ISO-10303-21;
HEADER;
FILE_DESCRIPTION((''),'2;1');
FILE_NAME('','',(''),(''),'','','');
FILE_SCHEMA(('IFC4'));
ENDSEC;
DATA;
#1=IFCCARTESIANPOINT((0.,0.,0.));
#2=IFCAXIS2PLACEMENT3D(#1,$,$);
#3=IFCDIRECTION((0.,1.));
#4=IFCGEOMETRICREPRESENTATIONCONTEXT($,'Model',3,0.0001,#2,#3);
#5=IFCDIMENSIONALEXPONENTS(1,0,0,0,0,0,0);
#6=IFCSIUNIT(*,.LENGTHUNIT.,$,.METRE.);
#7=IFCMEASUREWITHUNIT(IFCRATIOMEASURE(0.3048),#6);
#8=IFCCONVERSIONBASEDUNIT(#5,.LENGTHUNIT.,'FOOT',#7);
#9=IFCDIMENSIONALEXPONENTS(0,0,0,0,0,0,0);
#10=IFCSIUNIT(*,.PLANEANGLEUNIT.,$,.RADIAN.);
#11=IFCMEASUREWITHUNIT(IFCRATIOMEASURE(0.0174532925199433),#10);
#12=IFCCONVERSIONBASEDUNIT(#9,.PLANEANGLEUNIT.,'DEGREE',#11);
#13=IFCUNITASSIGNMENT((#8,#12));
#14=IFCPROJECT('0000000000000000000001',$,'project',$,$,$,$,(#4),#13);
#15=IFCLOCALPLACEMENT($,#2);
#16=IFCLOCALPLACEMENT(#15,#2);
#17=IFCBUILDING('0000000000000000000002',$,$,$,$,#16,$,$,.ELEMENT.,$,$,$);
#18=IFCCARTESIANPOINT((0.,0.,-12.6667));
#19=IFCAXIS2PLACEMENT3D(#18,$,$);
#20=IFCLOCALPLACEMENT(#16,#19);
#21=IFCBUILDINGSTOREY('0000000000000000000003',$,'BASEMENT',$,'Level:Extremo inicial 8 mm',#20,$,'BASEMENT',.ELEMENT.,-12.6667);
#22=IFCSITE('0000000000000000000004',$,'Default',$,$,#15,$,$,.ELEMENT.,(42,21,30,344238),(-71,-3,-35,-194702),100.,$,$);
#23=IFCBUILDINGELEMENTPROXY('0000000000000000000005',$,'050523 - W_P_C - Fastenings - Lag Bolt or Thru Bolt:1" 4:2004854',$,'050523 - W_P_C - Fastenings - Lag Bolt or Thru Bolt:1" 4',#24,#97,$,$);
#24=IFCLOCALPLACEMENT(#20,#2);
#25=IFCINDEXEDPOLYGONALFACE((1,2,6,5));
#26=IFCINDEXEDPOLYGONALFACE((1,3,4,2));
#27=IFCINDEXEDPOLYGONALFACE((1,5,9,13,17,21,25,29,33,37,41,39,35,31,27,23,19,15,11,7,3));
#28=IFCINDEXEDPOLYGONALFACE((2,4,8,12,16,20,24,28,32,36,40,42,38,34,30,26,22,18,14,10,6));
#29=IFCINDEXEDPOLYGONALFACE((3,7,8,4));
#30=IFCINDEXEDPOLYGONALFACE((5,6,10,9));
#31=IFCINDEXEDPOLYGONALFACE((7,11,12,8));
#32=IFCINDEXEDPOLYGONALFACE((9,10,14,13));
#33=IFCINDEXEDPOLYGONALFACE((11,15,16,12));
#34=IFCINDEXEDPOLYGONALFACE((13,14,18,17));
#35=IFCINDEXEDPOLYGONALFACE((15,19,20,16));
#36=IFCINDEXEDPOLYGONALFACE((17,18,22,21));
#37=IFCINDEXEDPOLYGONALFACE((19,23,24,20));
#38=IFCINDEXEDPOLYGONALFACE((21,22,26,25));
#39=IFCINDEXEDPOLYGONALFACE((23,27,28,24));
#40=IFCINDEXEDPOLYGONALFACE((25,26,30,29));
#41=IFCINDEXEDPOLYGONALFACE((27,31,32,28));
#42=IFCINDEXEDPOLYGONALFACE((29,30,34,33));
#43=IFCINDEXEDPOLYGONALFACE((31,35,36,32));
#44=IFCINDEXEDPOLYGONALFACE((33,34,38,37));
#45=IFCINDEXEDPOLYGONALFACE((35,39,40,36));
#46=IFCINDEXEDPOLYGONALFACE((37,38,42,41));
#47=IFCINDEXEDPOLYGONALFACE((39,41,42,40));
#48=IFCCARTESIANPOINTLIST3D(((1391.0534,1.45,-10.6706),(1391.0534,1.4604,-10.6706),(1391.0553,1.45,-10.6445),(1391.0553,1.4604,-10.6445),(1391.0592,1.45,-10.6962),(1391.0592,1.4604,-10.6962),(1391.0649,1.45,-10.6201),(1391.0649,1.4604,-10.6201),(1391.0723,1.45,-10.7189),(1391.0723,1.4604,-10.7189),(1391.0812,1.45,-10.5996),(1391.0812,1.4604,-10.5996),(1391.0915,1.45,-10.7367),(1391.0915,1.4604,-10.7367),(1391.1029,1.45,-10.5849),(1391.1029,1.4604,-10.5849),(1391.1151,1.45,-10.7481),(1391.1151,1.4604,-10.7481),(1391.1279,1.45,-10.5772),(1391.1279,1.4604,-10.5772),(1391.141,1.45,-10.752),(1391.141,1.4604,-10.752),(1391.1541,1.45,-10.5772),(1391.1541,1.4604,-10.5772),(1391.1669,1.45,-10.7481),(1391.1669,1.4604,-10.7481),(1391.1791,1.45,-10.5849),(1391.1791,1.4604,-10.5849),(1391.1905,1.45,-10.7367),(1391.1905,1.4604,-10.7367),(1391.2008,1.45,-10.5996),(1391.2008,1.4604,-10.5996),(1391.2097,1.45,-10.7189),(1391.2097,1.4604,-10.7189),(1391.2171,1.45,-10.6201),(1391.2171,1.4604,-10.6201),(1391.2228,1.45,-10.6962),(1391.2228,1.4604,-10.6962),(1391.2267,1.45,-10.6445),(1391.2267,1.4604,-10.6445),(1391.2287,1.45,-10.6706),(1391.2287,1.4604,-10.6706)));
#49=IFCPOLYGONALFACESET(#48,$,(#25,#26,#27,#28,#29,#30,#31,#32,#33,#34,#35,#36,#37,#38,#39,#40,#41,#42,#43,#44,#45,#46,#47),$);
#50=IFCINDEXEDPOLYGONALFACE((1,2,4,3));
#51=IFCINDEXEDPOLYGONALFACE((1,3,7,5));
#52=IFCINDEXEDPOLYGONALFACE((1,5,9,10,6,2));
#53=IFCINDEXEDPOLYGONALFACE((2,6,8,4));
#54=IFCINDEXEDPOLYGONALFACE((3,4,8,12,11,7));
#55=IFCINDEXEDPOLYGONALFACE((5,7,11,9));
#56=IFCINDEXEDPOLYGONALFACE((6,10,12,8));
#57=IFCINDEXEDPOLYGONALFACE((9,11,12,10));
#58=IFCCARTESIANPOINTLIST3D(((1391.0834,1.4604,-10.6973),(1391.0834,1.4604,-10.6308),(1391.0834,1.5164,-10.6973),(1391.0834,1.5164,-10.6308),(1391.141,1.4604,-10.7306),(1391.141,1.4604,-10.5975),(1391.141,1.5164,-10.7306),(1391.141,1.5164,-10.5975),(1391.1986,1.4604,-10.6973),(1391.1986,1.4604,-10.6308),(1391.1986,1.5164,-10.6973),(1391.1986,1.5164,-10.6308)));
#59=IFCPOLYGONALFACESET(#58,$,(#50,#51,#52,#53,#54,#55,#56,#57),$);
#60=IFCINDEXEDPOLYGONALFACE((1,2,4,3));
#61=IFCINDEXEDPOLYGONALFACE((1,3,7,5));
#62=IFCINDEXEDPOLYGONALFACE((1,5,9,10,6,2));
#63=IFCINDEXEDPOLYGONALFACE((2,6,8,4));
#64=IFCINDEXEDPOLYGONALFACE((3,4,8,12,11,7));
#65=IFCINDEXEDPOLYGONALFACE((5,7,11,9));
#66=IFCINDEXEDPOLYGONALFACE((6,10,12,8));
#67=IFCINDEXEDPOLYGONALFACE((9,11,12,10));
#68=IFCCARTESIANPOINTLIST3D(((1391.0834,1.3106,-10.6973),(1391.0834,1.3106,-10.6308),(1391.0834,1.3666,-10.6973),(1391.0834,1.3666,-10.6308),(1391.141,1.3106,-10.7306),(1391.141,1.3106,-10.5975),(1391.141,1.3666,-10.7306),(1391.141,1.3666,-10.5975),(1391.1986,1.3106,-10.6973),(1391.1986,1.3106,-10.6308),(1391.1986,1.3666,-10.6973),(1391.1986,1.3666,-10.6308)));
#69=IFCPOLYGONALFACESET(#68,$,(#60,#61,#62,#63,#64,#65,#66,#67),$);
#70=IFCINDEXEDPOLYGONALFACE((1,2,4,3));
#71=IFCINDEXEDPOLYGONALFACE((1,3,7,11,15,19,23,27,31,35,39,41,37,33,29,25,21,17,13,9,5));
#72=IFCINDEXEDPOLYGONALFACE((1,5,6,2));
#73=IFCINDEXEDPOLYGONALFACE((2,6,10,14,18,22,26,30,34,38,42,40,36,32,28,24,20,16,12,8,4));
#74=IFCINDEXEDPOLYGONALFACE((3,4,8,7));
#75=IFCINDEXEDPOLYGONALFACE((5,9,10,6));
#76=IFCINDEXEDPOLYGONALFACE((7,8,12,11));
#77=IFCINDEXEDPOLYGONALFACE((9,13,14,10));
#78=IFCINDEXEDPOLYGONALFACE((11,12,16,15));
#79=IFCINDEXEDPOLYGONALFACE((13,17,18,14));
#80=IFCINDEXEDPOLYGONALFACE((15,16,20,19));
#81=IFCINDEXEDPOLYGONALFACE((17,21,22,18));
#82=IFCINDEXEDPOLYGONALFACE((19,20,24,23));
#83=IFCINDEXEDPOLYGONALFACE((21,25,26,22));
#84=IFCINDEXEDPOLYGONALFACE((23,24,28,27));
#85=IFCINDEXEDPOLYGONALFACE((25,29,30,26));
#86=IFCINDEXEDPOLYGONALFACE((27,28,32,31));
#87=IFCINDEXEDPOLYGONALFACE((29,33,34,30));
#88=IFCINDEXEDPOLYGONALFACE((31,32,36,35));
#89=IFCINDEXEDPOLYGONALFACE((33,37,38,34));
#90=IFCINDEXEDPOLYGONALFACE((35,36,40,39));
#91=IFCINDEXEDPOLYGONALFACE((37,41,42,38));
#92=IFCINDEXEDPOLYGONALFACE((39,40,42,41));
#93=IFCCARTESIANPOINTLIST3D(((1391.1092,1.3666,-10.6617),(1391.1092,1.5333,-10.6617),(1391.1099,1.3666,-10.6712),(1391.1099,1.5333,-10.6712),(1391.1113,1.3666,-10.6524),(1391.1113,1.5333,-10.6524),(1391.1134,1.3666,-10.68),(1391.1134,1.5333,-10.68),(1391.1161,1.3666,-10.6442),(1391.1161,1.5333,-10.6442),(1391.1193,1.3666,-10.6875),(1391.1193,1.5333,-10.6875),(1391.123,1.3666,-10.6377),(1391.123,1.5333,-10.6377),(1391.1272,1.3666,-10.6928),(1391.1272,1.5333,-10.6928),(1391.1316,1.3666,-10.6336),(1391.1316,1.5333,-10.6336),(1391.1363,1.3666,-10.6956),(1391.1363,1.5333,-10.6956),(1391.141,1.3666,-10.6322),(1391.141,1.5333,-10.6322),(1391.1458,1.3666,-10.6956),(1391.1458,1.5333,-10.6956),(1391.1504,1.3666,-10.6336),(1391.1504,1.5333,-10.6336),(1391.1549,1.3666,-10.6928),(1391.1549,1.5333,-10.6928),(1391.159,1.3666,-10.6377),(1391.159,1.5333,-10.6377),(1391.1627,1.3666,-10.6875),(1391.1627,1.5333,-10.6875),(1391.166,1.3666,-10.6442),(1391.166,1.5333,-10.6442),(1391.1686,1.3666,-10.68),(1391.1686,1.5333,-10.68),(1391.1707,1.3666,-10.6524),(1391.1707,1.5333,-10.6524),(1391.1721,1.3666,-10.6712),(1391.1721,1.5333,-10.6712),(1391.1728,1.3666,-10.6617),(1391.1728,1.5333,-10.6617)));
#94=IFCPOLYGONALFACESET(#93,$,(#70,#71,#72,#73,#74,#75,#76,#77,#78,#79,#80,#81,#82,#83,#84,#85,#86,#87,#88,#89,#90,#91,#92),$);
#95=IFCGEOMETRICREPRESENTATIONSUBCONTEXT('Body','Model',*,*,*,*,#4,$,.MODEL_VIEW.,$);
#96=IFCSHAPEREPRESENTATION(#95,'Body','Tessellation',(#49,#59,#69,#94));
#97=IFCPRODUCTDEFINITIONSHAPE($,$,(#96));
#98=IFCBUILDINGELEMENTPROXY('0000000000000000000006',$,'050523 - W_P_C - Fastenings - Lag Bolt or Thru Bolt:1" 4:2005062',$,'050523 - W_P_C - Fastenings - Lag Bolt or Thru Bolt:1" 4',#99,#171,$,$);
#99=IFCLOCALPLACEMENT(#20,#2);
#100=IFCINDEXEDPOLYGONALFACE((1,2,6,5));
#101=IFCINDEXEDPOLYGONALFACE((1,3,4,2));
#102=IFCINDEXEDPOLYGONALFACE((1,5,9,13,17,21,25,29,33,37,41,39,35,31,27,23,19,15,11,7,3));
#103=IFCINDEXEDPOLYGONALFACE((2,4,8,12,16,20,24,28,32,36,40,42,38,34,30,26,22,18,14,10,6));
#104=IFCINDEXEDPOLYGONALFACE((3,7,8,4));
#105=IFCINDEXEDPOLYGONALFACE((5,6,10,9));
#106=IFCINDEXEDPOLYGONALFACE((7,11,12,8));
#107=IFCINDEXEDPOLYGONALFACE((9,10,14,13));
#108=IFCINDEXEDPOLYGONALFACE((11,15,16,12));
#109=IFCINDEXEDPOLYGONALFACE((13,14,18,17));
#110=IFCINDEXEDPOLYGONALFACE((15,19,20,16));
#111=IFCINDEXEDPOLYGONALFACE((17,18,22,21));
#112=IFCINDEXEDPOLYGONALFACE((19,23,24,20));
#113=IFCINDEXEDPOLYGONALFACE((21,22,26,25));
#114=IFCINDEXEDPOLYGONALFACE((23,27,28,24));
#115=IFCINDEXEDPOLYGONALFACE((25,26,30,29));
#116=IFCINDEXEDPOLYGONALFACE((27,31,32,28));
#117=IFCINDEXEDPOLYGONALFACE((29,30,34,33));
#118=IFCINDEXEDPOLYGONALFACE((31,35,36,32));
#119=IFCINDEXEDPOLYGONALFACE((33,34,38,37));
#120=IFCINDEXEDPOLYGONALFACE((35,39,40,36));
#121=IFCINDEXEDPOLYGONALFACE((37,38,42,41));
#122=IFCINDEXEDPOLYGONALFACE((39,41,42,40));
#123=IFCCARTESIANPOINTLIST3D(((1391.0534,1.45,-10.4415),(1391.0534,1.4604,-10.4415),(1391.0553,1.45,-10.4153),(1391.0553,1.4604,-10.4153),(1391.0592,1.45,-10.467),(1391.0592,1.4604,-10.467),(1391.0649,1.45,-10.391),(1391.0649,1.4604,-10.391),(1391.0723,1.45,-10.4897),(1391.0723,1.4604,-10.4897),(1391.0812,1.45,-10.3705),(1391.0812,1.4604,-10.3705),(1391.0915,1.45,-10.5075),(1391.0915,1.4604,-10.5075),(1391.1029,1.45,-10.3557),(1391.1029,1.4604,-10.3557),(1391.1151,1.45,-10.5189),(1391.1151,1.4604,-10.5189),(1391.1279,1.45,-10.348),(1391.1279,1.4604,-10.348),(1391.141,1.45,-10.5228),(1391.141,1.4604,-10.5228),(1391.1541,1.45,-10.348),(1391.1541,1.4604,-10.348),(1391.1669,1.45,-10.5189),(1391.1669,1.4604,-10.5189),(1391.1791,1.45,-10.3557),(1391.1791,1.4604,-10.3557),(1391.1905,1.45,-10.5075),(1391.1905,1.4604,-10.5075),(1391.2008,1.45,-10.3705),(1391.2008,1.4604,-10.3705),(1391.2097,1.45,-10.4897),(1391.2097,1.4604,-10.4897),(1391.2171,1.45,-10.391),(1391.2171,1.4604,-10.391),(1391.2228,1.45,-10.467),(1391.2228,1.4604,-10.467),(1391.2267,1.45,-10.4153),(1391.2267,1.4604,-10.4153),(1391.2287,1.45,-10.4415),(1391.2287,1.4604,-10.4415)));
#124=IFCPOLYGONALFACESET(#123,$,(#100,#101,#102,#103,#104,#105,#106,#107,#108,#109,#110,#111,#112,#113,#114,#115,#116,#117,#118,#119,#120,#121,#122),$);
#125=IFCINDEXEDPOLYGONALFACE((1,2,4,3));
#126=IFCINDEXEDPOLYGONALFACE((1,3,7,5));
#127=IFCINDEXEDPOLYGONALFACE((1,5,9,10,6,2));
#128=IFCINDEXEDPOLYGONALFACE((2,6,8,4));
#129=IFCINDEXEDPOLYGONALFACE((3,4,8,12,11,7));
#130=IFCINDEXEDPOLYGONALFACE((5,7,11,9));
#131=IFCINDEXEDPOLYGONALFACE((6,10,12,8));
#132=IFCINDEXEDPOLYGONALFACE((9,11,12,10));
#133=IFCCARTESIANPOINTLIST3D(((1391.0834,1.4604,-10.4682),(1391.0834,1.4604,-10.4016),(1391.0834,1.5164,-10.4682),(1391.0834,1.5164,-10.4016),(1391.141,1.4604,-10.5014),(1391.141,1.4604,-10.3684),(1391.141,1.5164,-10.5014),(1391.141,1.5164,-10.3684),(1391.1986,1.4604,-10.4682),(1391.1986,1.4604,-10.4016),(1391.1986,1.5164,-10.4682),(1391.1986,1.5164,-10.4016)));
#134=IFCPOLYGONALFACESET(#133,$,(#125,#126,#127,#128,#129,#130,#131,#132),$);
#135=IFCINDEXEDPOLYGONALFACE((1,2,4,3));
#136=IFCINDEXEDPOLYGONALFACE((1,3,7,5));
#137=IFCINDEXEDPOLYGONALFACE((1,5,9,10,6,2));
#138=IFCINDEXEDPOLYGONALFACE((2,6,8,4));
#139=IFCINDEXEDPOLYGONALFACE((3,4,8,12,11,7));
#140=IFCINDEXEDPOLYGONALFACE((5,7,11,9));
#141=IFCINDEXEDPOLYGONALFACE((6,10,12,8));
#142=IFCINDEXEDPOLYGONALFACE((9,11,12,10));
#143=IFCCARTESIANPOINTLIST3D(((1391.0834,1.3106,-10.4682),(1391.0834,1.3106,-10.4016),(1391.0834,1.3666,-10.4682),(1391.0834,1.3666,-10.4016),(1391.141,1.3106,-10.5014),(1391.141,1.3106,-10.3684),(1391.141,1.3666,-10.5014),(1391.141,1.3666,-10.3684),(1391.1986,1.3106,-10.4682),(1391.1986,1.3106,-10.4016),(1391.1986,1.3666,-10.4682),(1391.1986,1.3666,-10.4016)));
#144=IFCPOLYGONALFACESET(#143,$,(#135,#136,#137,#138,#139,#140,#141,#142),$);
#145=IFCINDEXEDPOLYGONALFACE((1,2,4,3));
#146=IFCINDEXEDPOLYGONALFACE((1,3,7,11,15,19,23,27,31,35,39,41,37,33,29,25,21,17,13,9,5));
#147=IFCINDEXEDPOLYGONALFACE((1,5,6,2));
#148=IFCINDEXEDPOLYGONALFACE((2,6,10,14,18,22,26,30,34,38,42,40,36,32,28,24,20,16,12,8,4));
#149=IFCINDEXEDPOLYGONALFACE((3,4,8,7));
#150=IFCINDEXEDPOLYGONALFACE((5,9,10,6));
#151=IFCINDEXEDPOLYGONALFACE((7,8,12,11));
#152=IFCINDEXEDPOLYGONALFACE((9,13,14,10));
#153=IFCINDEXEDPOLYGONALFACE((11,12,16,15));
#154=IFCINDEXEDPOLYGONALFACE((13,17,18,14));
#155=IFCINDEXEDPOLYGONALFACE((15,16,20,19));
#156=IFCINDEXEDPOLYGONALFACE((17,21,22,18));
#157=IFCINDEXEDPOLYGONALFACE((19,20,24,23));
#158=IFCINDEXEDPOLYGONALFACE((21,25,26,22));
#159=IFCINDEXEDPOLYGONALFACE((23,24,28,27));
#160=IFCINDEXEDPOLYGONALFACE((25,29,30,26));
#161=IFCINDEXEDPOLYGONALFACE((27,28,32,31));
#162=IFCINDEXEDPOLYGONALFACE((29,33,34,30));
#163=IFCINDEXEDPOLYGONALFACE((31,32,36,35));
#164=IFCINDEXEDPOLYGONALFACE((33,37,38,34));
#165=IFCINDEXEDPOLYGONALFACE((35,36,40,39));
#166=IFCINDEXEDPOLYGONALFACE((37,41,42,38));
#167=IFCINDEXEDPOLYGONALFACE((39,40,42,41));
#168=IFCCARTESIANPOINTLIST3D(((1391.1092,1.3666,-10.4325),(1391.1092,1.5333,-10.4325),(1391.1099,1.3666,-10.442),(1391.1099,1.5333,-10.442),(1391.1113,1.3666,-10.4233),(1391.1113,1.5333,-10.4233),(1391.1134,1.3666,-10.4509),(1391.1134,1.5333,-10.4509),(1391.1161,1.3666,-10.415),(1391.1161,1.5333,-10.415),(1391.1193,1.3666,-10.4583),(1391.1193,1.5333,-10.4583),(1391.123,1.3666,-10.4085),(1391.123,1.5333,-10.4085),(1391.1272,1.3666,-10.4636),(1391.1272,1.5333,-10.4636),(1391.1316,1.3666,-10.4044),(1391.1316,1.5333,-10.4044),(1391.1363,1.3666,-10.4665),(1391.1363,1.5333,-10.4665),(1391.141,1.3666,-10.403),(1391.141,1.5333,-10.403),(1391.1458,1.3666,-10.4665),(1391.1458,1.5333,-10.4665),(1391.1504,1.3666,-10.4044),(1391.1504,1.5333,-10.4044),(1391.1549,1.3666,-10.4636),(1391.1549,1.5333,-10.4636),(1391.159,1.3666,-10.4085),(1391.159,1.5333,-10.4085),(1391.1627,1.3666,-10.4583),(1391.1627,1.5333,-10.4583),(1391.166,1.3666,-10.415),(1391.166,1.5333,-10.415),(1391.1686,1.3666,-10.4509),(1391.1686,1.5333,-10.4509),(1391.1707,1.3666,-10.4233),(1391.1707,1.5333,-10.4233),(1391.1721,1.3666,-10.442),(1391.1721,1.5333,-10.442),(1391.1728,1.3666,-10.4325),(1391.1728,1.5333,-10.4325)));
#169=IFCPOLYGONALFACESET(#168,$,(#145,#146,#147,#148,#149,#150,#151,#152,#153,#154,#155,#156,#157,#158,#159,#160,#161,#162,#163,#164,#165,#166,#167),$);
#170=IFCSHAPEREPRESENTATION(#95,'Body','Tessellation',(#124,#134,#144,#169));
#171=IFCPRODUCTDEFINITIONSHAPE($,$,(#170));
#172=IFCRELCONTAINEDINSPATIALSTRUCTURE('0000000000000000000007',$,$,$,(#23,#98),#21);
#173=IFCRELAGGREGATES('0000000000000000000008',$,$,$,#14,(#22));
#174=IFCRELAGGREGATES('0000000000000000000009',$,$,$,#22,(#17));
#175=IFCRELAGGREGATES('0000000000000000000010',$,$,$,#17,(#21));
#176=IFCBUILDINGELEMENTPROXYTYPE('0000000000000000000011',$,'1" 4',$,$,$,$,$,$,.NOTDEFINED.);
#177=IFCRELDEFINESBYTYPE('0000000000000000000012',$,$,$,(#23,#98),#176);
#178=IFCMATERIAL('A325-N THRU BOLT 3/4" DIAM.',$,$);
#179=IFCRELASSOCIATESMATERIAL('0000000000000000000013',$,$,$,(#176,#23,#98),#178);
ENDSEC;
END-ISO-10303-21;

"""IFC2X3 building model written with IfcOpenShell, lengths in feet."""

from ifc_helpers import new_model, entity, si_unit, converted_unit, direction, frame, frame_2d, origin, place, context, subcontext, project, spatial, polyline, circle, outline, extrude, source, transform, mapped, material, type_object, type_shapes, element, save


model = new_model("IFC2X3")

# Units and contexts
model_context = context("Model", 3, precision=0.0001, world=origin(), true_north=direction((0.0, 1.0)))
body_context = subcontext(model_context, "Body", "Model", "MODEL_VIEW")
ifc_project = project(units=[converted_unit("LENGTHUNIT", "FOOT", entity("IfcRatioMeasure", 0.3048), si_unit("LENGTHUNIT", "METRE"), dimensions=[1, 0, 0, 0, 0, 0, 0]), converted_unit("PLANEANGLEUNIT", "DEGREE", entity("IfcRatioMeasure", 0.0174532925199433), si_unit("PLANEANGLEUNIT", "RADIAN"), dimensions=[0, 0, 0, 0, 0, 0, 0])], contexts=[model_context])

# Site, building, storey
site_placement = place(None, origin())
site = spatial("IfcSite", under=ifc_project, at=site_placement, Name="Default", CompositionType="ELEMENT", RefLatitude=(42, 21, 30, 344238), RefLongitude=(-71, -3, -35, -194702), RefElevation=100.0)
building_placement = place(site_placement, origin())
building = spatial("IfcBuilding", under=site, at=building_placement, CompositionType="ELEMENT")
storey_placement = place(building_placement, frame((0.0, 0.0, -12.6667)))
storey = spatial("IfcBuildingStorey", under=building, at=storey_placement, Name="BASEMENT", ObjectType="Level:Extremo inicial 8 mm", LongName="BASEMENT", CompositionType="ELEMENT", Elevation=-12.6667)

# Building element proxies
ifc_material_1 = material(Name="A325-N THRU BOLT 3/4\" DIAM.")
building_element_proxy_type_1 = type_object("IfcBuildingElementProxyType", Name="1\" 4", PredefinedType="NOTDEFINED", material=ifc_material_1)
shared_shape_1 = source(origin(), body_context, "Body", "SweptSolid", [
    extrude(circle(Radius=0.0879, at=frame_2d((0.0, 0.0), x_axis=(1.0, 0.0))), frame((0.0, 0.0, -0.0938), z_axis=(0.0, 0.0, 1.0), x_axis=(0.0, -1.0, 0.0)), (0.0, 0.0, 1.0), 0.0104),
    extrude(outline(polyline([(-0.0333, -0.0576), (0.0333, -0.0576), (0.0665, 0.0), (0.0333, 0.0576), (-0.0333, 0.0576), (-0.0665, 0.0), (-0.0333, -0.0576)])), frame((0.0, 0.0, -0.1497), z_axis=(0.0, 0.0, 1.0), x_axis=(0.866025, -0.5, 0.0)), (0.0, 0.0, 1.0), 0.056),
    extrude(outline(polyline([(-0.0333, -0.0576), (0.0333, -0.0576), (0.0665, 0.0), (0.0333, 0.0576), (-0.0333, 0.0576), (-0.0665, 0.0), (-0.0333, -0.0576)])), frame((0.0, 0.0, 0.0), z_axis=(0.0, 0.0, 1.0), x_axis=(0.0, -1.0, 0.0)), (0.0, 0.0, 1.0), 0.056),
    extrude(circle(Radius=0.0319, at=frame_2d((0.0, 0.0), x_axis=(1.0, 0.0))), frame((0.0, 0.0, -0.1667), z_axis=(0.0, 0.0, 1.0), x_axis=(0.0, 1.0, 0.0)), (0.0, 0.0, 1.0), 0.1667),
])
type_shapes(building_element_proxy_type_1, [shared_shape_1])
for number, where, z_axis, x_axis, name in (
    (1, (1391.141, 1.3666, -10.6641), (0.0, -1.0, 0.0), (1.0, 0.0, 0.0), "050523 - W_P_C - Fastenings - Lag Bolt or Thru Bolt:1\" 4:2004854"),
    (2, (1391.141, 1.3666, -10.4349), (0.0, -1.0, 0.0), (1.0, 0.0, 0.0), "050523 - W_P_C - Fastenings - Lag Bolt or Thru Bolt:1\" 4:2005062"),
):
    element("IfcBuildingElementProxy", number, at=place(storey_placement, frame(where, z_axis=z_axis, x_axis=x_axis)), inside=storey, type_object=building_element_proxy_type_1, material=ifc_material_1, Name=name, ObjectType="050523 - W_P_C - Fastenings - Lag Bolt or Thru Bolt:1\" 4", context=body_context, shape_type="MappedRepresentation", body=[
        mapped(shared_shape_1, transform((0.0, 0.0, 0.0), scale=1.0)),
    ])

save(model, "model.ifc")
